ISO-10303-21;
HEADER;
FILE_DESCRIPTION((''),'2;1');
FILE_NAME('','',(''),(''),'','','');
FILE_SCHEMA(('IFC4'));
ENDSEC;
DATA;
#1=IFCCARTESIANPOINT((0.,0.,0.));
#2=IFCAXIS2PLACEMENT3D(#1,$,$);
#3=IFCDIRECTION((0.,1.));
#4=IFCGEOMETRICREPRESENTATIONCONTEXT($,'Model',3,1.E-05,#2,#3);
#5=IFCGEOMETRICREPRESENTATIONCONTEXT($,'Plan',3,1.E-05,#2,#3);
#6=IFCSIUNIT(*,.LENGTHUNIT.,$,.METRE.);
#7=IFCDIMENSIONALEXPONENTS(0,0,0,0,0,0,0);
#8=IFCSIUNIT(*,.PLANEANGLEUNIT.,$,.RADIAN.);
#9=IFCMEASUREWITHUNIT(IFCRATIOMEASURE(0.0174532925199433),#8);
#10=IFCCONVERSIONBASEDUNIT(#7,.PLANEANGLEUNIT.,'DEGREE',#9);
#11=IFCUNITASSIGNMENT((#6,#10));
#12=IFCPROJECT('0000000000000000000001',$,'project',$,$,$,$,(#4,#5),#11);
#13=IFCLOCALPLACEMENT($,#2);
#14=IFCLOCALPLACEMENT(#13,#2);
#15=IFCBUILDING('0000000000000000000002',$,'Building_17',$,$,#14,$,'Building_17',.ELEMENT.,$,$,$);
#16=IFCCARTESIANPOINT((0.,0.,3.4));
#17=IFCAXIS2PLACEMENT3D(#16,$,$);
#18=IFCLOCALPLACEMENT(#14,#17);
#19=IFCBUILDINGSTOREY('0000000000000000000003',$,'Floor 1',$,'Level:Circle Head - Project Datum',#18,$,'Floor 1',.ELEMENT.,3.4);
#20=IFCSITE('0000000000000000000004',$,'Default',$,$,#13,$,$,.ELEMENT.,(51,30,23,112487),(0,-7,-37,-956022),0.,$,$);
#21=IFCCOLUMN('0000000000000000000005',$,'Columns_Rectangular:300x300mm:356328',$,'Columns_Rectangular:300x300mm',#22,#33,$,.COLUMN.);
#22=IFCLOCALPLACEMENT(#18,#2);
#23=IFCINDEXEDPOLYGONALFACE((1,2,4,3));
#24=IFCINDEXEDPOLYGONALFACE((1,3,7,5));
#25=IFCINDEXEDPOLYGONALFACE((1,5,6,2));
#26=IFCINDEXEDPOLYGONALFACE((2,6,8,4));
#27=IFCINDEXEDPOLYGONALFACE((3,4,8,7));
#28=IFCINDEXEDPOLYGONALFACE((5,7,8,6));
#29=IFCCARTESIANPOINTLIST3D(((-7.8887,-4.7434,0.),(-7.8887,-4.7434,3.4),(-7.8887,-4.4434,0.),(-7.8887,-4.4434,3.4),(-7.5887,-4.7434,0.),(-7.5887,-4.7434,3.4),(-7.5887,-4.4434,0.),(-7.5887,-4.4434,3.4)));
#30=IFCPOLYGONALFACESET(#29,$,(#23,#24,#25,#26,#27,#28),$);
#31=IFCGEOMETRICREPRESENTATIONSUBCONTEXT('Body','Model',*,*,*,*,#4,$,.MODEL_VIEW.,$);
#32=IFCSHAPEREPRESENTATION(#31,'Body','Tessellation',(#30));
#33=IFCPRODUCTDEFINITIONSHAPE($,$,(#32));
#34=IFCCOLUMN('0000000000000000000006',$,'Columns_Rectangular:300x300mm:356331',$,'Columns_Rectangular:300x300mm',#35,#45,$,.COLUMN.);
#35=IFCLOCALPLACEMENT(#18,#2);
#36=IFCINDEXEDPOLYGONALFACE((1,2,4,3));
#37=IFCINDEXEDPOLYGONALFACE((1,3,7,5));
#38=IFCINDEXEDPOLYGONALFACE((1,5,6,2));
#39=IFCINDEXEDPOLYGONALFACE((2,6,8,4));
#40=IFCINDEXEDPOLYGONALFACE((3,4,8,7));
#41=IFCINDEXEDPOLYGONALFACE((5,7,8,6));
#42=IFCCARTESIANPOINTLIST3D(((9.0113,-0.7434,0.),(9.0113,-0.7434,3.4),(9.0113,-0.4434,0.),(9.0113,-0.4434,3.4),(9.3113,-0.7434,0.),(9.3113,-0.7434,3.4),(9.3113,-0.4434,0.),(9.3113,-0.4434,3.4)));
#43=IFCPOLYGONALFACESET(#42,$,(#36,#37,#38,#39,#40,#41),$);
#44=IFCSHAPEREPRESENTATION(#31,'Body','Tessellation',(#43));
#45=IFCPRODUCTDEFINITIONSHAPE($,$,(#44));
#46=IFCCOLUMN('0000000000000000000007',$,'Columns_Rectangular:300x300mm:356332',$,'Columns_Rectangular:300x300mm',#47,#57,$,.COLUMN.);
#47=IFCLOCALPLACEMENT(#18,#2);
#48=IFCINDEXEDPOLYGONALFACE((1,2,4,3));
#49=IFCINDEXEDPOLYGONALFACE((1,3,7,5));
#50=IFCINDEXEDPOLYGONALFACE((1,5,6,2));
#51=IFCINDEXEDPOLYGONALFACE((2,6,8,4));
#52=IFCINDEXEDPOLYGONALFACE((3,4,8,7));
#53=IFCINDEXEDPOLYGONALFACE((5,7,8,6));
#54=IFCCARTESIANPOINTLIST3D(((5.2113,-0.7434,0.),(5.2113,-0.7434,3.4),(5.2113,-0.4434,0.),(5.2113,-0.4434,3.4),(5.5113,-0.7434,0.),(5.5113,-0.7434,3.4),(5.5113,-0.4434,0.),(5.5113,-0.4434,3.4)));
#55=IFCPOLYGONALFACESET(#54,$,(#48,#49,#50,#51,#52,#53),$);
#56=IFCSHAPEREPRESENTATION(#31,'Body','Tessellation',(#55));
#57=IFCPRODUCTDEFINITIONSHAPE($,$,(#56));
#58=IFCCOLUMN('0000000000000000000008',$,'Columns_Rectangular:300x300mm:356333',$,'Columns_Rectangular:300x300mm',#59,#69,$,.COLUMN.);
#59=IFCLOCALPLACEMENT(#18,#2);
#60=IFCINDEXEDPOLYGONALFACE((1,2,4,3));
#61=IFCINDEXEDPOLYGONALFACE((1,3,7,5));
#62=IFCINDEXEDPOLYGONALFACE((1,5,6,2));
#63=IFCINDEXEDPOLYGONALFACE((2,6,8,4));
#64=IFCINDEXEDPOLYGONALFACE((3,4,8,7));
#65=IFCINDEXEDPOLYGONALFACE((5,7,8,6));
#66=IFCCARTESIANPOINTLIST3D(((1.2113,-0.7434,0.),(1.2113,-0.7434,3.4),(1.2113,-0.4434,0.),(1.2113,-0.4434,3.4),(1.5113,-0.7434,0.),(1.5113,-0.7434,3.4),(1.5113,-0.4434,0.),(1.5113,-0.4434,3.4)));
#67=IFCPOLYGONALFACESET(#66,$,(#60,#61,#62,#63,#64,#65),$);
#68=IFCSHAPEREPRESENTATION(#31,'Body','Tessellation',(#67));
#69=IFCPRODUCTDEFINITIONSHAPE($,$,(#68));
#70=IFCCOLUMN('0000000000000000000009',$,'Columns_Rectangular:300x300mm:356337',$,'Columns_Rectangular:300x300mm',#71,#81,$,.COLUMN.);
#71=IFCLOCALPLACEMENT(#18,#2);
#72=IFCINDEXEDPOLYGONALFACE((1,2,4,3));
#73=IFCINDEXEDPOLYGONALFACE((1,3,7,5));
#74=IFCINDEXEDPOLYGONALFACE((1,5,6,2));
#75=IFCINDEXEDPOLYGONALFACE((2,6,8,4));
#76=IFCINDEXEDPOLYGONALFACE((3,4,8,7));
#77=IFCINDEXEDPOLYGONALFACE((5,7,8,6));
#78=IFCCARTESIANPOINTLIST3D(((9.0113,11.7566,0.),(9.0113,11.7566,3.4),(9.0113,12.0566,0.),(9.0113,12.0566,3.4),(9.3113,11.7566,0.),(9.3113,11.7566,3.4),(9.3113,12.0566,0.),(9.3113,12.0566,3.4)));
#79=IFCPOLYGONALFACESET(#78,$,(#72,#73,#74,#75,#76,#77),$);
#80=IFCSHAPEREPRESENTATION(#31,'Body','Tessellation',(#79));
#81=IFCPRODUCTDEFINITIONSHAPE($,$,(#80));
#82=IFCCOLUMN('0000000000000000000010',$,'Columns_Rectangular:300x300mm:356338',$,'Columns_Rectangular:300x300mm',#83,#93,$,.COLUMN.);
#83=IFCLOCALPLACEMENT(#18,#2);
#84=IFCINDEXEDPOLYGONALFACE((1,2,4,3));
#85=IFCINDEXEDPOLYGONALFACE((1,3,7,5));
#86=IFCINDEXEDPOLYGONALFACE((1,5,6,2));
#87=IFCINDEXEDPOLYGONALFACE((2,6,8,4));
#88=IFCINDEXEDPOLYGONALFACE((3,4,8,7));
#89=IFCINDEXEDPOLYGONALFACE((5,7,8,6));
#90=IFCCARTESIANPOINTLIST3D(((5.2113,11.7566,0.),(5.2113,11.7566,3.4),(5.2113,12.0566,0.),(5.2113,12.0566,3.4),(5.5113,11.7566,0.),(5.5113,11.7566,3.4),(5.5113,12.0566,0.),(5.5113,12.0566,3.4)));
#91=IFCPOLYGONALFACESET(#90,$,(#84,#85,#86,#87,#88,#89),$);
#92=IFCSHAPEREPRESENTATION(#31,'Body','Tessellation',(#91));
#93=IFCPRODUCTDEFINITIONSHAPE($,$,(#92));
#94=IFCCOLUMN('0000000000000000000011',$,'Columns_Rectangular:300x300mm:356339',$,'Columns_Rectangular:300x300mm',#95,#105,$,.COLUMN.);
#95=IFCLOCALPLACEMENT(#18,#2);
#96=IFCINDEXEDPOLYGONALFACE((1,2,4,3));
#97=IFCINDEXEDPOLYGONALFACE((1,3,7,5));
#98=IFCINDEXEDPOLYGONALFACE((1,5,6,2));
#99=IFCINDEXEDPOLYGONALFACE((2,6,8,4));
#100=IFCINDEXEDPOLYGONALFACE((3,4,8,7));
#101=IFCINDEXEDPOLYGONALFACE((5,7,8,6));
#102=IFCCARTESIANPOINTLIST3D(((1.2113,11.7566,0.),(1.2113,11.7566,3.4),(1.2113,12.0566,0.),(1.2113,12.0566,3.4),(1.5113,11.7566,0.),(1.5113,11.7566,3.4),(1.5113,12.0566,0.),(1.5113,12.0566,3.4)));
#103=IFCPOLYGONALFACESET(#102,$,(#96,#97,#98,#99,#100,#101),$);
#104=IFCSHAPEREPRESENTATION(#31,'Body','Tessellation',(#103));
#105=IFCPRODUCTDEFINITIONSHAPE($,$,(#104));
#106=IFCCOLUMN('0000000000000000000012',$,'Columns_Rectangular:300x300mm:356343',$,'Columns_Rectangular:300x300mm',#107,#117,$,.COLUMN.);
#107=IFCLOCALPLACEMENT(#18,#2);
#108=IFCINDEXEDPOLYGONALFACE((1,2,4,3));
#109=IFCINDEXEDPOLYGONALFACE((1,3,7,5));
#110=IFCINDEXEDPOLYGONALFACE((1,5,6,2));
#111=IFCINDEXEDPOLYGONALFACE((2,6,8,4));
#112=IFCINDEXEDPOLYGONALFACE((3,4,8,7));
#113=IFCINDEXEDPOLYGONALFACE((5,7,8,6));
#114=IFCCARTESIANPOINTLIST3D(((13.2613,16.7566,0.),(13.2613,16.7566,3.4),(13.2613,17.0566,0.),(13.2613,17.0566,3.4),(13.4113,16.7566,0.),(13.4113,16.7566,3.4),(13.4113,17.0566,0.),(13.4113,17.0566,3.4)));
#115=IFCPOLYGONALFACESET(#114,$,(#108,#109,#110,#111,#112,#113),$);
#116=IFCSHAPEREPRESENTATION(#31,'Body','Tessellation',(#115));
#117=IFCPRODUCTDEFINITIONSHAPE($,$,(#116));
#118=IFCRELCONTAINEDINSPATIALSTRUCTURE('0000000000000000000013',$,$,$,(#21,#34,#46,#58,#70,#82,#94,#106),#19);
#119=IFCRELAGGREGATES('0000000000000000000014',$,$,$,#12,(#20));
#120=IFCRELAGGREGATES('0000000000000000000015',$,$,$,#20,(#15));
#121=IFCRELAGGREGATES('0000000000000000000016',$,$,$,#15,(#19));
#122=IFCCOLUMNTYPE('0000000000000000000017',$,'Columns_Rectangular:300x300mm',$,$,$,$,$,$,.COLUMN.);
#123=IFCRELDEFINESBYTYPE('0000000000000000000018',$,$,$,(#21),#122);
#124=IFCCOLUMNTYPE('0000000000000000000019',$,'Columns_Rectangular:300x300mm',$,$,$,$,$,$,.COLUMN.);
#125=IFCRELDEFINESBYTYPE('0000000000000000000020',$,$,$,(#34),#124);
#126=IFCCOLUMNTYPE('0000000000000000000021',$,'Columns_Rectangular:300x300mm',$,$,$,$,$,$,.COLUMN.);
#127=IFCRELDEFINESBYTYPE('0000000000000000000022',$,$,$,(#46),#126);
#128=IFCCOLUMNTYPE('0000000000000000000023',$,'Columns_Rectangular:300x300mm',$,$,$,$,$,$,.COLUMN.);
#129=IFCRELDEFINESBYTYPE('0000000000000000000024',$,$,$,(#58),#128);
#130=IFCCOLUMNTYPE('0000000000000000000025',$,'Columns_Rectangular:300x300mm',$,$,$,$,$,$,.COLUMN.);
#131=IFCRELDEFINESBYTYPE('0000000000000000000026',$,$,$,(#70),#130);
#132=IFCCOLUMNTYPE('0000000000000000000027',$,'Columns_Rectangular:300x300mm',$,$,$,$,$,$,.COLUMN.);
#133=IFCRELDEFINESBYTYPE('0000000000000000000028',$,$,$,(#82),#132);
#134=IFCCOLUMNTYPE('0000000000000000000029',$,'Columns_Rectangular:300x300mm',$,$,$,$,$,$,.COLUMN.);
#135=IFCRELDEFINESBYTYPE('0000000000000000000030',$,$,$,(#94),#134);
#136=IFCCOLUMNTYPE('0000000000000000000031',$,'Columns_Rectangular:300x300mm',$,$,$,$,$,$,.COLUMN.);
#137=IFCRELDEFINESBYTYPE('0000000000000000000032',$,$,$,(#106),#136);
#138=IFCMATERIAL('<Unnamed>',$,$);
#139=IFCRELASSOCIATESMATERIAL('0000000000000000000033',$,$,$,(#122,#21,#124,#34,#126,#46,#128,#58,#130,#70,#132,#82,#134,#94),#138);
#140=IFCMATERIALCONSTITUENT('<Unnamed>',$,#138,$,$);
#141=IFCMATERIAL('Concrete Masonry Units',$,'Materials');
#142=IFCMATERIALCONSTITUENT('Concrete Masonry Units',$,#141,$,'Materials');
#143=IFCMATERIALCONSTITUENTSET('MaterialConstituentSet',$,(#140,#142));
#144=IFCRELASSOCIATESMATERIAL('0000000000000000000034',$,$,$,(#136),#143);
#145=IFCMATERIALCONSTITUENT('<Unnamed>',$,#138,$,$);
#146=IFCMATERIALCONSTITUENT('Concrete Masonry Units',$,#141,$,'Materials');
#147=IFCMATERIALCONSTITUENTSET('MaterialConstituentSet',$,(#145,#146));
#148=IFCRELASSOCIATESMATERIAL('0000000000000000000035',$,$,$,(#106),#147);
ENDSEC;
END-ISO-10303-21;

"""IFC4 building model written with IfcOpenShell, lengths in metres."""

from ifc_helpers import new_model, entity, si_unit, converted_unit, direction, frame, origin, place, context, subcontext, project, spatial, indexed_curve, outline, extrude, source, transform, mapped, material, constituent, constituent_set, type_object, type_shapes, element, save


model = new_model("IFC4")

# Units and contexts
model_context = context("Model", 3, precision=1e-05, world=origin(), true_north=direction((0.0, 1.0)))
plan_context = context("Plan", 3, precision=1e-05, world=origin(), true_north=direction((0.0, 1.0)))
body_context = subcontext(model_context, "Body", "Model", "MODEL_VIEW")
ifc_project = project(units=[si_unit("LENGTHUNIT", "METRE"), converted_unit("PLANEANGLEUNIT", "DEGREE", entity("IfcRatioMeasure", 0.0174532925199433), si_unit("PLANEANGLEUNIT", "RADIAN"), dimensions=[0, 0, 0, 0, 0, 0, 0])], contexts=[model_context, plan_context])

# Site, building, storey
site_placement = place(None, origin())
site = spatial("IfcSite", under=ifc_project, at=site_placement, Name="Default", CompositionType="ELEMENT", RefLatitude=(51, 30, 23, 112487), RefLongitude=(0, -7, -37, -956022), RefElevation=0.0)
building_placement = place(site_placement, origin())
building = spatial("IfcBuilding", under=site, at=building_placement, Name="Building_17", LongName="Building_17", CompositionType="ELEMENT")
storey_placement = place(building_placement, frame((0.0, 0.0, 3.4)))
storey = spatial("IfcBuildingStorey", under=building, at=storey_placement, Name="Floor 1", ObjectType="Level:Circle Head - Project Datum", LongName="Floor 1", CompositionType="ELEMENT", Elevation=3.4)

# Columns
ifc_material_1 = material(Name="<Unnamed>")
ifc_material_2 = material(Name="Concrete Masonry Units", Category="Materials")
column_type_1 = type_object("IfcColumnType", Name="Columns_Rectangular:300x300mm", PredefinedType="COLUMN", material=ifc_material_1)
shared_shape_1 = source(origin(), body_context, "Body", "SweptSolid", [
    extrude(outline(indexed_curve([(-0.15, -0.15), (0.15, -0.15), (0.15, 0.15), (-0.15, 0.15), (-0.15, -0.15)], self_intersect=False)), frame((-7.7387, -4.5934, 3.4), z_axis=(0.0, 0.0, 1.0), x_axis=(0.0, -1.0, 0.0)), (0.0, 0.0, 1.0), 3.4),
])
type_shapes(column_type_1, [shared_shape_1])
column_1_placement = place(storey_placement, frame((0.0, 0.0, -3.4)))
element("IfcColumn", 1, at=column_1_placement, inside=storey, type_object=column_type_1, material=ifc_material_1, Name="Columns_Rectangular:300x300mm:356328", ObjectType="Columns_Rectangular:300x300mm", PredefinedType="COLUMN", context=body_context, shape_type="MappedRepresentation", body=[
    mapped(shared_shape_1, transform((0.0, 0.0, 0.0), scale=1.0)),
])
column_type_2 = type_object("IfcColumnType", Name="Columns_Rectangular:300x300mm", PredefinedType="COLUMN", material=ifc_material_1)
shared_shape_2 = source(origin(), body_context, "Body", "SweptSolid", [
    extrude(outline(indexed_curve([(-0.15, -0.15), (0.15, -0.15), (0.15, 0.15), (-0.15, 0.15), (-0.15, -0.15)], self_intersect=False)), frame((9.1613, -0.5934, 3.4), z_axis=(0.0, 0.0, 1.0), x_axis=(0.0, -1.0, 0.0)), (0.0, 0.0, 1.0), 3.4),
])
type_shapes(column_type_2, [shared_shape_2])
column_2_placement = place(storey_placement, frame((0.0, 0.0, -3.4)))
element("IfcColumn", 2, at=column_2_placement, inside=storey, type_object=column_type_2, material=ifc_material_1, Name="Columns_Rectangular:300x300mm:356331", ObjectType="Columns_Rectangular:300x300mm", PredefinedType="COLUMN", context=body_context, shape_type="MappedRepresentation", body=[
    mapped(shared_shape_2, transform((0.0, 0.0, 0.0), scale=1.0)),
])
column_type_3 = type_object("IfcColumnType", Name="Columns_Rectangular:300x300mm", PredefinedType="COLUMN", material=ifc_material_1)
shared_shape_3 = source(origin(), body_context, "Body", "SweptSolid", [
    extrude(outline(indexed_curve([(-0.15, -0.15), (0.15, -0.15), (0.15, 0.15), (-0.15, 0.15), (-0.15, -0.15)], self_intersect=False)), frame((5.3613, -0.5934, 3.4), z_axis=(0.0, 0.0, 1.0), x_axis=(0.0, -1.0, 0.0)), (0.0, 0.0, 1.0), 3.4),
])
type_shapes(column_type_3, [shared_shape_3])
column_3_placement = place(storey_placement, frame((0.0, 0.0, -3.4)))
element("IfcColumn", 3, at=column_3_placement, inside=storey, type_object=column_type_3, material=ifc_material_1, Name="Columns_Rectangular:300x300mm:356332", ObjectType="Columns_Rectangular:300x300mm", PredefinedType="COLUMN", context=body_context, shape_type="MappedRepresentation", body=[
    mapped(shared_shape_3, transform((0.0, 0.0, 0.0), scale=1.0)),
])
column_type_4 = type_object("IfcColumnType", Name="Columns_Rectangular:300x300mm", PredefinedType="COLUMN", material=ifc_material_1)
shared_shape_4 = source(origin(), body_context, "Body", "SweptSolid", [
    extrude(outline(indexed_curve([(-0.15, -0.15), (0.15, -0.15), (0.15, 0.15), (-0.15, 0.15), (-0.15, -0.15)], self_intersect=False)), frame((1.3613, -0.5934, 3.4), z_axis=(0.0, 0.0, 1.0), x_axis=(0.0, -1.0, 0.0)), (0.0, 0.0, 1.0), 3.4),
])
type_shapes(column_type_4, [shared_shape_4])
column_4_placement = place(storey_placement, frame((0.0, 0.0, -3.4)))
element("IfcColumn", 4, at=column_4_placement, inside=storey, type_object=column_type_4, material=ifc_material_1, Name="Columns_Rectangular:300x300mm:356333", ObjectType="Columns_Rectangular:300x300mm", PredefinedType="COLUMN", context=body_context, shape_type="MappedRepresentation", body=[
    mapped(shared_shape_4, transform((0.0, 0.0, 0.0), scale=1.0)),
])
column_type_5 = type_object("IfcColumnType", Name="Columns_Rectangular:300x300mm", PredefinedType="COLUMN", material=ifc_material_1)
shared_shape_5 = source(origin(), body_context, "Body", "SweptSolid", [
    extrude(outline(indexed_curve([(-0.15, -0.15), (0.15, -0.15), (0.15, 0.15), (-0.15, 0.15), (-0.15, -0.15)], self_intersect=False)), frame((9.1613, 11.9066, 3.4), z_axis=(0.0, 0.0, 1.0), x_axis=(0.0, -1.0, 0.0)), (0.0, 0.0, 1.0), 3.4),
])
type_shapes(column_type_5, [shared_shape_5])
column_5_placement = place(storey_placement, frame((0.0, 0.0, -3.4)))
element("IfcColumn", 5, at=column_5_placement, inside=storey, type_object=column_type_5, material=ifc_material_1, Name="Columns_Rectangular:300x300mm:356337", ObjectType="Columns_Rectangular:300x300mm", PredefinedType="COLUMN", context=body_context, shape_type="MappedRepresentation", body=[
    mapped(shared_shape_5, transform((0.0, 0.0, 0.0), scale=1.0)),
])
column_type_6 = type_object("IfcColumnType", Name="Columns_Rectangular:300x300mm", PredefinedType="COLUMN", material=ifc_material_1)
shared_shape_6 = source(origin(), body_context, "Body", "SweptSolid", [
    extrude(outline(indexed_curve([(-0.15, -0.15), (0.15, -0.15), (0.15, 0.15), (-0.15, 0.15), (-0.15, -0.15)], self_intersect=False)), frame((5.3613, 11.9066, 3.4), z_axis=(0.0, 0.0, 1.0), x_axis=(0.0, -1.0, 0.0)), (0.0, 0.0, 1.0), 3.4),
])
type_shapes(column_type_6, [shared_shape_6])
column_6_placement = place(storey_placement, frame((0.0, 0.0, -3.4)))
element("IfcColumn", 6, at=column_6_placement, inside=storey, type_object=column_type_6, material=ifc_material_1, Name="Columns_Rectangular:300x300mm:356338", ObjectType="Columns_Rectangular:300x300mm", PredefinedType="COLUMN", context=body_context, shape_type="MappedRepresentation", body=[
    mapped(shared_shape_6, transform((0.0, 0.0, 0.0), scale=1.0)),
])
column_type_7 = type_object("IfcColumnType", Name="Columns_Rectangular:300x300mm", PredefinedType="COLUMN", material=ifc_material_1)
shared_shape_7 = source(origin(), body_context, "Body", "SweptSolid", [
    extrude(outline(indexed_curve([(-0.15, -0.15), (0.15, -0.15), (0.15, 0.15), (-0.15, 0.15), (-0.15, -0.15)], self_intersect=False)), frame((1.3613, 11.9066, 3.4), z_axis=(0.0, 0.0, 1.0), x_axis=(0.0, -1.0, 0.0)), (0.0, 0.0, 1.0), 3.4),
])
type_shapes(column_type_7, [shared_shape_7])
column_7_placement = place(storey_placement, frame((0.0, 0.0, -3.4)))
element("IfcColumn", 7, at=column_7_placement, inside=storey, type_object=column_type_7, material=ifc_material_1, Name="Columns_Rectangular:300x300mm:356339", ObjectType="Columns_Rectangular:300x300mm", PredefinedType="COLUMN", context=body_context, shape_type="MappedRepresentation", body=[
    mapped(shared_shape_7, transform((0.0, 0.0, 0.0), scale=1.0)),
])
ifc_constituent_1 = constituent(ifc_material_1, Name="<Unnamed>")
ifc_constituent_2 = constituent(ifc_material_2, Name="Concrete Masonry Units", Category="Materials")
ifc_constituent_set_1 = constituent_set(constituents=[ifc_constituent_1, ifc_constituent_2], Name="MaterialConstituentSet")
ifc_constituent_3 = constituent(ifc_material_1, Name="<Unnamed>")
ifc_constituent_4 = constituent(ifc_material_2, Name="Concrete Masonry Units", Category="Materials")
ifc_constituent_set_2 = constituent_set(constituents=[ifc_constituent_3, ifc_constituent_4], Name="MaterialConstituentSet")
column_type_8 = type_object("IfcColumnType", Name="Columns_Rectangular:300x300mm", PredefinedType="COLUMN", material=ifc_constituent_set_2)
shared_shape_8 = source(origin(), body_context, "Body", "SweptSolid", [
    extrude(outline(indexed_curve([(-0.15, -0.075), (0.15, -0.075), (0.15, 0.075), (-0.15, 0.075), (-0.15, -0.075)], self_intersect=False)), frame((13.3363, 16.9066, 3.4), z_axis=(0.0, 0.0, 1.0), x_axis=(0.0, -1.0, 0.0)), (0.0, 0.0, 1.0), 3.4),
])
type_shapes(column_type_8, [shared_shape_8])
column_8_placement = place(storey_placement, frame((0.0, 0.0, -3.4)))
element("IfcColumn", 8, at=column_8_placement, inside=storey, type_object=column_type_8, material=ifc_constituent_set_1, Name="Columns_Rectangular:300x300mm:356343", ObjectType="Columns_Rectangular:300x300mm", PredefinedType="COLUMN", context=body_context, shape_type="MappedRepresentation", body=[
    mapped(shared_shape_8, transform((0.0, 0.0, 0.0), scale=1.0)),
])

save(model, "model.ifc")
